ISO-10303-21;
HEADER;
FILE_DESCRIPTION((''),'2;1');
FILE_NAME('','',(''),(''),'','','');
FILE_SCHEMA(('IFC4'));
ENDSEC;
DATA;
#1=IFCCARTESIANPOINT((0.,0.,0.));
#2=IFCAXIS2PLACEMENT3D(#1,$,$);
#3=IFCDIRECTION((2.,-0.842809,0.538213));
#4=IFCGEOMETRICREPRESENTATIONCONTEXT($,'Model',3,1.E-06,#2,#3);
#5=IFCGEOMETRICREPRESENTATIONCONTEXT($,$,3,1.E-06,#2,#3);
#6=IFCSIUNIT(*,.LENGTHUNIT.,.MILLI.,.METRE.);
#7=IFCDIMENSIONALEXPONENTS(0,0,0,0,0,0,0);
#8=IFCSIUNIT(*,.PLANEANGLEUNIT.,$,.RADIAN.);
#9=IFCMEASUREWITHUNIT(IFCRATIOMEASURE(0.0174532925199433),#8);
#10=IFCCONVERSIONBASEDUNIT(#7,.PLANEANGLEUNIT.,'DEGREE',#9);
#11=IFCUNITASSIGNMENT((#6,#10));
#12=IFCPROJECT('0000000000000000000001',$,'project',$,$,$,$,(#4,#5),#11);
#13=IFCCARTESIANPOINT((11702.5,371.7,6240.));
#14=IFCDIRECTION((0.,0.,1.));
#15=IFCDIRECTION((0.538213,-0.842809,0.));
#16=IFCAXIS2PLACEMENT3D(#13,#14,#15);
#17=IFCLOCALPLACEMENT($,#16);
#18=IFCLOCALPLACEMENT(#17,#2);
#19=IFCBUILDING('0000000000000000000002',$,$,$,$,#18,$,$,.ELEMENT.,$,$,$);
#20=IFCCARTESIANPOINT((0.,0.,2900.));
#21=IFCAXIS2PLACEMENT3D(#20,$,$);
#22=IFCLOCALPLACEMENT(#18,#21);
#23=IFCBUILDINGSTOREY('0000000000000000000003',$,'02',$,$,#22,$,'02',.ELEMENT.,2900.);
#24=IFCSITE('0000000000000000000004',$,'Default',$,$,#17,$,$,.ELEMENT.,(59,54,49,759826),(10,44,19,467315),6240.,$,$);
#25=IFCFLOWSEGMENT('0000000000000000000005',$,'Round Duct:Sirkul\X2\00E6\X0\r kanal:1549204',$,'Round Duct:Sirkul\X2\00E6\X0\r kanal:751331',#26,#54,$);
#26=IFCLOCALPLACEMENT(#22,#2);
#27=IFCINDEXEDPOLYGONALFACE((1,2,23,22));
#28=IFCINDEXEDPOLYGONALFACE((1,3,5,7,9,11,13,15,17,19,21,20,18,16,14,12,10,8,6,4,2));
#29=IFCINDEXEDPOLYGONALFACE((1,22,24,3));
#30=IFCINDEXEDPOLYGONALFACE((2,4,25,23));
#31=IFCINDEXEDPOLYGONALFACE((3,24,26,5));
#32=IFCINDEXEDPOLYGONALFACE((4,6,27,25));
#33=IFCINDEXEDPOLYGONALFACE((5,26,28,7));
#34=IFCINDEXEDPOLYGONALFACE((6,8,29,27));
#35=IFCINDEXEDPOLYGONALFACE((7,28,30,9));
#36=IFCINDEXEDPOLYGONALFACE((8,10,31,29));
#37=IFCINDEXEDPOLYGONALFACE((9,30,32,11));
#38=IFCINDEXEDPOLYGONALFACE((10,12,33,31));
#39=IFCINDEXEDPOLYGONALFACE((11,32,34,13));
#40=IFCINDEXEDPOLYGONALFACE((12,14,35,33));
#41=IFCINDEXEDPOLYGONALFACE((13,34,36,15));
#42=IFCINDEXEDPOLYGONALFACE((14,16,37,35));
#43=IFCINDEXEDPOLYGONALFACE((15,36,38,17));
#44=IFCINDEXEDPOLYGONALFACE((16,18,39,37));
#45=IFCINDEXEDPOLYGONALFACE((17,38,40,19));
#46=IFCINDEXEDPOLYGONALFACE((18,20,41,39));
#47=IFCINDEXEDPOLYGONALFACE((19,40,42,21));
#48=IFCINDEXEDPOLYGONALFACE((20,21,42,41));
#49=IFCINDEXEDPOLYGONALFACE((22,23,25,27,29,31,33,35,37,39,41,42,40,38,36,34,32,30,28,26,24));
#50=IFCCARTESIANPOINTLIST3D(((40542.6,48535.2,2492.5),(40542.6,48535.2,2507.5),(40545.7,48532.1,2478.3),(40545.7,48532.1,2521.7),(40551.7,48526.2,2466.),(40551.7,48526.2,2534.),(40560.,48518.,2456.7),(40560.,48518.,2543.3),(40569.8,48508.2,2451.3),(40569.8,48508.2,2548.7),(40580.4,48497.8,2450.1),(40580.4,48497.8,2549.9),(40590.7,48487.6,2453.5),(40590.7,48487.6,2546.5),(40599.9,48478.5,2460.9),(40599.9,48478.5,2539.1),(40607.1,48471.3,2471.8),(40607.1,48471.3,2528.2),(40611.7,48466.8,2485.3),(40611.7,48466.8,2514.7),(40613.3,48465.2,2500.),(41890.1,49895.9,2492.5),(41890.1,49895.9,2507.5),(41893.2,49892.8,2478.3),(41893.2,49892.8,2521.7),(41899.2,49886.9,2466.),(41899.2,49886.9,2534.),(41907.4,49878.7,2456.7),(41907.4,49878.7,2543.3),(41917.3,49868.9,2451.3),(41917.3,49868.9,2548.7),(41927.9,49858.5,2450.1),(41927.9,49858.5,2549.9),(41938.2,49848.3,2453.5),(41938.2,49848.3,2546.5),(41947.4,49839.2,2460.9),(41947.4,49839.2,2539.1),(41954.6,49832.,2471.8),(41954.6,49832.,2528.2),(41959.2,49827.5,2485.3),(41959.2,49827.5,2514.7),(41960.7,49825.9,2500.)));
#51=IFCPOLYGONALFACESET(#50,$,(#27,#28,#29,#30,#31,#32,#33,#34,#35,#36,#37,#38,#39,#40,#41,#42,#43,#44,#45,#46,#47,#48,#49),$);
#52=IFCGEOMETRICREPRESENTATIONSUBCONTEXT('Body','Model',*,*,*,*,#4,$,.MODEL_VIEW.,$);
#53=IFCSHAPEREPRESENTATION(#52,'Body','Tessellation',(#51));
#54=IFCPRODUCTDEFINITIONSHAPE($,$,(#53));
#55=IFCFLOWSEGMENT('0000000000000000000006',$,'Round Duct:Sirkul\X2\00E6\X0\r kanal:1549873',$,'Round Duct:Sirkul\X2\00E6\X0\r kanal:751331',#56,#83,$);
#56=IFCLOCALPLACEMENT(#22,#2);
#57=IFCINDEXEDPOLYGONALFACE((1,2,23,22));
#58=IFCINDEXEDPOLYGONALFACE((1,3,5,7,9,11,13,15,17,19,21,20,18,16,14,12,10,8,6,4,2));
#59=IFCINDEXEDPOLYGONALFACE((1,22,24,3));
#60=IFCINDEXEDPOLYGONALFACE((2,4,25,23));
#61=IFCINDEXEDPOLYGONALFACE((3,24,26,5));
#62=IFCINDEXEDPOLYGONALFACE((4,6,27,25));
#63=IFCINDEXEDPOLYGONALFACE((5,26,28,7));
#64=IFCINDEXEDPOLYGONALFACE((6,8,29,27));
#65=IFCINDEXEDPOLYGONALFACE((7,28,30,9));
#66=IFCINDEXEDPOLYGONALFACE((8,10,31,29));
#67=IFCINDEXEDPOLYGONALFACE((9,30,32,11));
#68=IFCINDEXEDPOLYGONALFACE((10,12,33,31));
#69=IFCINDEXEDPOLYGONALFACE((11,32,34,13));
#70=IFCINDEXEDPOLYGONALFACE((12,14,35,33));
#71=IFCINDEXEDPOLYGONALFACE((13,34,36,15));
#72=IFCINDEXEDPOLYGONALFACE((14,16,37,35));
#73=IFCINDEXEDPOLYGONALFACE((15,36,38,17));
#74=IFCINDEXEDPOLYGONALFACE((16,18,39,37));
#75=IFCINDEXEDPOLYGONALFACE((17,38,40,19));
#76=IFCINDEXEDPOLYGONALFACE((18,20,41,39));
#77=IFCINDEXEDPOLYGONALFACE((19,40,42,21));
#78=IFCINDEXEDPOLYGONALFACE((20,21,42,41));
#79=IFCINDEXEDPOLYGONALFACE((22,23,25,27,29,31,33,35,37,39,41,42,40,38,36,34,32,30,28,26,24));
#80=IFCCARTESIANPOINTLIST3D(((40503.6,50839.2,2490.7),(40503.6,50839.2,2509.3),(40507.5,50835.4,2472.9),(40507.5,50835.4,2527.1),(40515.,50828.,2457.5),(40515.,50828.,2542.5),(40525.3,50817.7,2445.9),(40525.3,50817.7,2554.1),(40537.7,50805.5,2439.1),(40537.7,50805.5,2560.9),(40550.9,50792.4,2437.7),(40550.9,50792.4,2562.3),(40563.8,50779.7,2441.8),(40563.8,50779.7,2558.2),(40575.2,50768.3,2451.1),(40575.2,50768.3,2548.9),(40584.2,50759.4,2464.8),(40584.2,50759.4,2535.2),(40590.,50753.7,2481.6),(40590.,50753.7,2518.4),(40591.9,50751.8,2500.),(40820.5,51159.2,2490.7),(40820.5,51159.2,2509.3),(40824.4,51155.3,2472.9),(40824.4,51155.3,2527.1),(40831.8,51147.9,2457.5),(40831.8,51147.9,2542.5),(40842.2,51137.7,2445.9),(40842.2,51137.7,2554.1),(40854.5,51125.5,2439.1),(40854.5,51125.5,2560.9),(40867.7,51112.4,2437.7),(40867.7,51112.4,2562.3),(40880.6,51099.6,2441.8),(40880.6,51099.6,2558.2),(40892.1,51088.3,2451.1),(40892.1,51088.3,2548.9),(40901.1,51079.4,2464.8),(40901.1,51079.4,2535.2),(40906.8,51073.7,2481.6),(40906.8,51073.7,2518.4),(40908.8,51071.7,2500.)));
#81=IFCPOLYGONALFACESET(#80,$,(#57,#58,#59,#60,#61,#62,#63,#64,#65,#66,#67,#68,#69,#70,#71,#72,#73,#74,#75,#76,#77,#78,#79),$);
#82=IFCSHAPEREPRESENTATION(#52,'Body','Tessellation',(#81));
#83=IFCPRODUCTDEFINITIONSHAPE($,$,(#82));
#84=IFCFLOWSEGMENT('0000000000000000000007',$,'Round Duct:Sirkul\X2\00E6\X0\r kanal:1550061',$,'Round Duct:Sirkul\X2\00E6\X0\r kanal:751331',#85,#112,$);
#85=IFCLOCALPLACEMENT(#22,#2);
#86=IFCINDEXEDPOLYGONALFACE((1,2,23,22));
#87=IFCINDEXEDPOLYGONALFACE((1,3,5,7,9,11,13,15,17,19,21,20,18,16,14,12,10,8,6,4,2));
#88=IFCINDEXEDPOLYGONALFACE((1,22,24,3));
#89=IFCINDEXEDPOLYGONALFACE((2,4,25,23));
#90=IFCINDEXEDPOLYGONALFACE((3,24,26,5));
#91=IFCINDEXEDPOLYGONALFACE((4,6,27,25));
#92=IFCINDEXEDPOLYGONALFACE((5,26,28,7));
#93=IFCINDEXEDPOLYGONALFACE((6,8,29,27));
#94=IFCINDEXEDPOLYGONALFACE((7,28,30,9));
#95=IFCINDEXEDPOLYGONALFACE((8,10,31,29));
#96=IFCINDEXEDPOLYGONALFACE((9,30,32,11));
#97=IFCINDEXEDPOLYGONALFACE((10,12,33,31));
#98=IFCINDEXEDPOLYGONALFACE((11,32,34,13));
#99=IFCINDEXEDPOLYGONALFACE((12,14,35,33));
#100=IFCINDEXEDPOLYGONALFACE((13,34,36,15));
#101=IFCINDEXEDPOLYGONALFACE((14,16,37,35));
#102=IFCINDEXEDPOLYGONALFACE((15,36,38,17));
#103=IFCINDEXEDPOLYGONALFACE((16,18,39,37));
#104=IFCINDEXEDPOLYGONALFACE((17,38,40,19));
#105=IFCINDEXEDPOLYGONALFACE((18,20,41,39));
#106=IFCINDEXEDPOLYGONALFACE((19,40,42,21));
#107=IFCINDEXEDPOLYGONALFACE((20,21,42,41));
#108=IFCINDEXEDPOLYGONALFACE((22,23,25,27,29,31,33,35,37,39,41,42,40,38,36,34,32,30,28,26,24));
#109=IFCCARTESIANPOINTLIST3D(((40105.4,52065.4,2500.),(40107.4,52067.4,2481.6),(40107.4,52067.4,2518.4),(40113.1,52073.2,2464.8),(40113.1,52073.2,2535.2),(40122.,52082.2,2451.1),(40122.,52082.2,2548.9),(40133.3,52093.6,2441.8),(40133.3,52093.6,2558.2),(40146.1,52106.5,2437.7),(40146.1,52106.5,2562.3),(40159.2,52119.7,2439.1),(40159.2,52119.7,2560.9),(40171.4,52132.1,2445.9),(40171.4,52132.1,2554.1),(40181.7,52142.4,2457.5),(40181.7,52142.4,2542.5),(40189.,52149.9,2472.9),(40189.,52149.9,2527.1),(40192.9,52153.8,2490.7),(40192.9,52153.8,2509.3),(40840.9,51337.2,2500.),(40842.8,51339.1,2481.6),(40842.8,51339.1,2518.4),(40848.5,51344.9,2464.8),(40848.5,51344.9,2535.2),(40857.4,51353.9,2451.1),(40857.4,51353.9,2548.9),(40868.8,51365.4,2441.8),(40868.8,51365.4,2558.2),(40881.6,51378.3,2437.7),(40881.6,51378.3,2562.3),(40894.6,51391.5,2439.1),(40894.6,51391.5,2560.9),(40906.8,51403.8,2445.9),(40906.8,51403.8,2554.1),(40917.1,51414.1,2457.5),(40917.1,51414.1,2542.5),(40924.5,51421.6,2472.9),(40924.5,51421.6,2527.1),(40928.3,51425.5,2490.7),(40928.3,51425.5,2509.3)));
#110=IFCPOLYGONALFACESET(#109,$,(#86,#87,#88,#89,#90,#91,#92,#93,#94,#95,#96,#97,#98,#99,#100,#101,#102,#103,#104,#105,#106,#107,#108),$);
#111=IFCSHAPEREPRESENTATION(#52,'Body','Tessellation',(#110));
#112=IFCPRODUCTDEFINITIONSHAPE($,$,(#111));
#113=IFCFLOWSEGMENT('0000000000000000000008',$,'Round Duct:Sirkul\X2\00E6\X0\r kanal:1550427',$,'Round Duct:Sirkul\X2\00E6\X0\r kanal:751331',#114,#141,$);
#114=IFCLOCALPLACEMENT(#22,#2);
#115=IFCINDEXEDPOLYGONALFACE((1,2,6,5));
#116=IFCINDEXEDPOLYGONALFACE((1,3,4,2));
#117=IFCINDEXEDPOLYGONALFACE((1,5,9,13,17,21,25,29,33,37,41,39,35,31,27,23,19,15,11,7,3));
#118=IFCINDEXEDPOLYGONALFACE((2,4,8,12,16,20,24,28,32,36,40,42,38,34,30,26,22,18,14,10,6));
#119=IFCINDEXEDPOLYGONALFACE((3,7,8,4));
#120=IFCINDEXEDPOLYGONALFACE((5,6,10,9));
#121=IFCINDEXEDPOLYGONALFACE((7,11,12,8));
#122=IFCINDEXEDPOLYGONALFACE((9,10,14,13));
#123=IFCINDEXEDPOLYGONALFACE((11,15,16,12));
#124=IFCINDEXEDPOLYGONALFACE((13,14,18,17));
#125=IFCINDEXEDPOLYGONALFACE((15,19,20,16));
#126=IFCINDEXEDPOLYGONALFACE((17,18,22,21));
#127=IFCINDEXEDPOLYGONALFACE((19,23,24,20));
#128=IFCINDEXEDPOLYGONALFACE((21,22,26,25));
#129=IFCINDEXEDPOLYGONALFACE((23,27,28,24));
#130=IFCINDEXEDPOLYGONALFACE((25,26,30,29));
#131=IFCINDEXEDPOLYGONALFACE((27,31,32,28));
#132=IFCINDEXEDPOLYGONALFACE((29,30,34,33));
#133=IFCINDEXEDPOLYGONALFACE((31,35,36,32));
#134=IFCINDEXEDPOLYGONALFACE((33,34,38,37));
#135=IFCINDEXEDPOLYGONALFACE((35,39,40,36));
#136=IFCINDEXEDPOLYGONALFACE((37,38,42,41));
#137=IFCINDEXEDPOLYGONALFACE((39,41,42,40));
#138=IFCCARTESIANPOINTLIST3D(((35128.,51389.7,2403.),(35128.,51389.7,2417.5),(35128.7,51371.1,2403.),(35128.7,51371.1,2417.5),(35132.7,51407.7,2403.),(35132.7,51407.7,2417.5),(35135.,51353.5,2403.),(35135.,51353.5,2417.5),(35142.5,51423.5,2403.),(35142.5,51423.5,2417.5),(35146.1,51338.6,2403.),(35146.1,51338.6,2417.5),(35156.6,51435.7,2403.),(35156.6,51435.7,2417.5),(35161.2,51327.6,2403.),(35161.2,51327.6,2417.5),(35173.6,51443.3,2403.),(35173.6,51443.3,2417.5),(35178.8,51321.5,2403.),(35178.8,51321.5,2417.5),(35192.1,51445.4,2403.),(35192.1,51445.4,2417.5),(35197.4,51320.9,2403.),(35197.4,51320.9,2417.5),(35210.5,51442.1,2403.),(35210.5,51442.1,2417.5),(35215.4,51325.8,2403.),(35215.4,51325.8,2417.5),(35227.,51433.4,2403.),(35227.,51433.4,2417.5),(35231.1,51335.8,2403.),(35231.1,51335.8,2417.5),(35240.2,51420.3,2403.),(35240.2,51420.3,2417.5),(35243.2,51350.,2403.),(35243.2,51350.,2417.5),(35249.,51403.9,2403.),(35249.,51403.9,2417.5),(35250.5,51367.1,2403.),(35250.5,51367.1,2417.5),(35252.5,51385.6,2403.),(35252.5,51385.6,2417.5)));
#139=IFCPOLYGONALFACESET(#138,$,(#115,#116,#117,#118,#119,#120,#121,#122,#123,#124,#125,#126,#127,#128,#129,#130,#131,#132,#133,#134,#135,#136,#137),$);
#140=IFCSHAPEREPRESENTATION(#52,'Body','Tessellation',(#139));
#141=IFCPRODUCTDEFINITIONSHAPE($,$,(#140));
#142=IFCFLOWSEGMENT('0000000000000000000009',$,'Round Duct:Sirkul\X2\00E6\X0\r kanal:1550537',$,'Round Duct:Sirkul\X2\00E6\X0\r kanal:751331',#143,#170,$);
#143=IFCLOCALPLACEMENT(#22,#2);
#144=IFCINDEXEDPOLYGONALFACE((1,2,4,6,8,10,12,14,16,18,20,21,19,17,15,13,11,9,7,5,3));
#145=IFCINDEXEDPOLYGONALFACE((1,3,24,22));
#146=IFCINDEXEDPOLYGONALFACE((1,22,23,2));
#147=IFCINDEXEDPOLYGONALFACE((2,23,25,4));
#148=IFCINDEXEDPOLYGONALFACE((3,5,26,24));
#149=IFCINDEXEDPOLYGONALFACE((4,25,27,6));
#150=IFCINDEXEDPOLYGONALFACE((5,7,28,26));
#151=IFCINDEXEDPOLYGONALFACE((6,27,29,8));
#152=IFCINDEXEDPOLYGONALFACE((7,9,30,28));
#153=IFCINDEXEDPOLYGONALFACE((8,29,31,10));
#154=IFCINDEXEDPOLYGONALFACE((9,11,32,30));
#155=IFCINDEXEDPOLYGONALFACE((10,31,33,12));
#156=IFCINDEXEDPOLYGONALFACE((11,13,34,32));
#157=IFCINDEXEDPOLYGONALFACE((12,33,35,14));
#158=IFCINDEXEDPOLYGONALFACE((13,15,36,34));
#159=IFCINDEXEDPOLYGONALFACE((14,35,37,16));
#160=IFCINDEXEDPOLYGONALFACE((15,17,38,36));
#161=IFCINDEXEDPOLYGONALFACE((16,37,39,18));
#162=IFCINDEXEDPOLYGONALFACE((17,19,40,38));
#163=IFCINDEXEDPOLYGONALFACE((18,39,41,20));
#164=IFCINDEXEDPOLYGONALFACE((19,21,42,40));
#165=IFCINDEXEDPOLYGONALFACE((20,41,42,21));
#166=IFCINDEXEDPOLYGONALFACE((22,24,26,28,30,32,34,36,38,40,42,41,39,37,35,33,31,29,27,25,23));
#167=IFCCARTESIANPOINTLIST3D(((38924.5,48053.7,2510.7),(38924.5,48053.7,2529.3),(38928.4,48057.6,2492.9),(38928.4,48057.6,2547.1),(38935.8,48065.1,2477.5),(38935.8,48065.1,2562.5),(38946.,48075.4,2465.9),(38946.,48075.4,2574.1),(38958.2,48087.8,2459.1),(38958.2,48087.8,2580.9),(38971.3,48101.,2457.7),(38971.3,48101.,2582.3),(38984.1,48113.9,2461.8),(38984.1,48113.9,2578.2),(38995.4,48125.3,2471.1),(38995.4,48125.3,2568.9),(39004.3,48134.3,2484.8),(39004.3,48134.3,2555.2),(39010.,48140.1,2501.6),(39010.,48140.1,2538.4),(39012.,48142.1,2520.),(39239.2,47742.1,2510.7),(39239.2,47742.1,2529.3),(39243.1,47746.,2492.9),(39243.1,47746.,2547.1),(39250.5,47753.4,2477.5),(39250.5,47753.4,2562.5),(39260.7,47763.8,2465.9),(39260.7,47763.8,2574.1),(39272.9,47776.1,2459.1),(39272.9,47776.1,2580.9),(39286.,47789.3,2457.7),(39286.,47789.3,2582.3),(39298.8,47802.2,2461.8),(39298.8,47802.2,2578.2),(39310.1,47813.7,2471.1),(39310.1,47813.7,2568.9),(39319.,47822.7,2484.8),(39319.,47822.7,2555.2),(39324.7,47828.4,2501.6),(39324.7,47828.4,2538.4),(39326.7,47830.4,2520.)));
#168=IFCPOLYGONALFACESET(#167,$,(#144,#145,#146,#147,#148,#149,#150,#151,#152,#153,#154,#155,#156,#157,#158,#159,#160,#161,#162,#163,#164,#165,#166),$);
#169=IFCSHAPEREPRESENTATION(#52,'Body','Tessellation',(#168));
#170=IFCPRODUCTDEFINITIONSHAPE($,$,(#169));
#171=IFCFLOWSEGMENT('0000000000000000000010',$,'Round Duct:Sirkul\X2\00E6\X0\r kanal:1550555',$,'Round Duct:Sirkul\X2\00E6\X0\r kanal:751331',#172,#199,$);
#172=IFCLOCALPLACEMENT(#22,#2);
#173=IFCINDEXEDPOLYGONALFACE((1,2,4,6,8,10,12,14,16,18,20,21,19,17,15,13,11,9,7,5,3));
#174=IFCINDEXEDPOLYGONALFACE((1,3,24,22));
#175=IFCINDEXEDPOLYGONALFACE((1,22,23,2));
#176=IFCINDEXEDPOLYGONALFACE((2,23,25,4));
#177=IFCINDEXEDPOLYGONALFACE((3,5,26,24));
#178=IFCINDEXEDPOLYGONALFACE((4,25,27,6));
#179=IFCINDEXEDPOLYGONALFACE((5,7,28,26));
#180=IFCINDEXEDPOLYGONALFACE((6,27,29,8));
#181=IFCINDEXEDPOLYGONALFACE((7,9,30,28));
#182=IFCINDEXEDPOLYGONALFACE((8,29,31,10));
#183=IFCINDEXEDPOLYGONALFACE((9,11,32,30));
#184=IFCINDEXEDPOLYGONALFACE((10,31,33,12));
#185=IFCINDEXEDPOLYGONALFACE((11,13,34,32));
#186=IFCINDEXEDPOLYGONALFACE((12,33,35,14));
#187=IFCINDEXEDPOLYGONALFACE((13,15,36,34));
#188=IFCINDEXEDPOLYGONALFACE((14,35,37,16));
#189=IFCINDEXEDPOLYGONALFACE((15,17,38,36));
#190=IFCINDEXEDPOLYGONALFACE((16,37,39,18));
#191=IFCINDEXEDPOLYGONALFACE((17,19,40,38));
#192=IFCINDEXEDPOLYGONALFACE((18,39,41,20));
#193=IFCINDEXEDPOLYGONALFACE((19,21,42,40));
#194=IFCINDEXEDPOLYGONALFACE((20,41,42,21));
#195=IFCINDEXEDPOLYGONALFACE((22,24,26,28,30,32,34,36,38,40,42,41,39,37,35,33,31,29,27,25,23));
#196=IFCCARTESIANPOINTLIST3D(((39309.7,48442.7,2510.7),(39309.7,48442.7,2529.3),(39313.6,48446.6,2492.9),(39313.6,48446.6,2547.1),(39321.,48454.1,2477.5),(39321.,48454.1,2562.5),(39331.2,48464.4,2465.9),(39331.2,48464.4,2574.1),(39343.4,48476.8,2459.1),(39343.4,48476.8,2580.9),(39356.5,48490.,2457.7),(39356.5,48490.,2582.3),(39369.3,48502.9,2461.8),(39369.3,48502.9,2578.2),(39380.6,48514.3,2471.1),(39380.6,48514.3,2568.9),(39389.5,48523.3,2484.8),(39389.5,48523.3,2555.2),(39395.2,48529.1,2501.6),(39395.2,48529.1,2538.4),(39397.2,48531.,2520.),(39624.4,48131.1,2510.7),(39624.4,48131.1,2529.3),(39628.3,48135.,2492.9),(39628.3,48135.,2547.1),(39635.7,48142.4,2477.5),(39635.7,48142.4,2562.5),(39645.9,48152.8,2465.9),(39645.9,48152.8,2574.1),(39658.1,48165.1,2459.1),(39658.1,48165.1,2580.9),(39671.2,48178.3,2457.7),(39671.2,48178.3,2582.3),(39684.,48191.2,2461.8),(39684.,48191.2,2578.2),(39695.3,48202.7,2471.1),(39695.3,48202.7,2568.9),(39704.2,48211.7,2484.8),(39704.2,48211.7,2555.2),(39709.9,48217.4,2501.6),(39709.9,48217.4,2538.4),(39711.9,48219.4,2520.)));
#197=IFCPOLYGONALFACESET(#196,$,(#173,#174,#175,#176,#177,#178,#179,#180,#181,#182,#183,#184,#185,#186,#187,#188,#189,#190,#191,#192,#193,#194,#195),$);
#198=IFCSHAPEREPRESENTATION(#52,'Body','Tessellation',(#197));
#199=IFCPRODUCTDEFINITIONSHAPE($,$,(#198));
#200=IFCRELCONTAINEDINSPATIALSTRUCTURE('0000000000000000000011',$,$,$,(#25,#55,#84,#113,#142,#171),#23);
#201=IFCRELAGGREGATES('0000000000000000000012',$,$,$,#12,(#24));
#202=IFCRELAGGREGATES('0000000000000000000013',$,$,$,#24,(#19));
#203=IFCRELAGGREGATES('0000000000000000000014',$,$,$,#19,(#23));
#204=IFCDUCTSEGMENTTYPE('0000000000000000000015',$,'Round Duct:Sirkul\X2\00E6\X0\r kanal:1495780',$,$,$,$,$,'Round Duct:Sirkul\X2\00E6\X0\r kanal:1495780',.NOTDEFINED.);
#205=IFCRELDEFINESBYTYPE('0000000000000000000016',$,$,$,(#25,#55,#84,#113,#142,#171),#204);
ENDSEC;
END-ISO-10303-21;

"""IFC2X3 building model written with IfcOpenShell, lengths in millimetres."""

from ifc_helpers import new_model, entity, si_unit, converted_unit, direction, frame, frame_2d, origin, origin_2d_with_axis, place, context, subcontext, project, spatial, circle, extrude, type_object, element, save


model = new_model("IFC2X3")

# Units and contexts
model_context = context("Model", 3, precision=1e-06, world=origin(), true_north=direction((2.0, -0.842809, 0.538213)))
context_of_model = context(None, 3, precision=1e-06, world=origin(), true_north=direction((2.0, -0.842809, 0.538213)))
body_context = subcontext(model_context, "Body", "Model", "MODEL_VIEW")
ifc_project = project(units=[si_unit("LENGTHUNIT", "METRE", prefix="MILLI"), converted_unit("PLANEANGLEUNIT", "DEGREE", entity("IfcRatioMeasure", 0.0174532925199433), si_unit("PLANEANGLEUNIT", "RADIAN"), dimensions=[0, 0, 0, 0, 0, 0, 0])], contexts=[model_context, context_of_model])

# Site, building, storey
site_placement = place(None, frame((11702.5, 371.7, 6240.0), z_axis=(0.0, 0.0, 1.0), x_axis=(0.538213, -0.842809, 0.0)))
site = spatial("IfcSite", under=ifc_project, at=site_placement, Name="Default", CompositionType="ELEMENT", RefLatitude=(59, 54, 49, 759826), RefLongitude=(10, 44, 19, 467315), RefElevation=6240.0)
building_placement = place(site_placement, origin())
building = spatial("IfcBuilding", under=site, at=building_placement, CompositionType="ELEMENT")
storey_placement = place(building_placement, frame((0.0, 0.0, 2900.0)))
storey = spatial("IfcBuildingStorey", under=building, at=storey_placement, Name="02", LongName="02", CompositionType="ELEMENT", Elevation=2900.0)

# Flow segments
duct_segment_type_1 = type_object("IfcDuctSegmentType", Name="Round Duct:Sirkulær kanal:1495780", ElementType="Round Duct:Sirkulær kanal:1495780", PredefinedType="NOTDEFINED")
flow_segment_1_placement = place(storey_placement, origin())
element("IfcFlowSegment", 1, at=flow_segment_1_placement, inside=storey, type_object=duct_segment_type_1, Name="Round Duct:Sirkulær kanal:1549204", ObjectType="Round Duct:Sirkulær kanal:751331", context=body_context, shape_type="SweptSolid", body=[
    extrude(circle(Radius=50.0, at=origin_2d_with_axis()), frame((40577.7, 48500.4, 2500.0), z_axis=(0.703643, 0.710554, 0.0), x_axis=(0.710554, -0.703643, 0.0)), (0.0, 0.0, 1.0), 1915.0),
])
flow_segment_2_placement = place(storey_placement, origin())
element("IfcFlowSegment", 2, at=flow_segment_2_placement, inside=storey, type_object=duct_segment_type_1, Name="Round Duct:Sirkulær kanal:1549873", ObjectType="Round Duct:Sirkulær kanal:751331", context=body_context, shape_type="SweptSolid", body=[
    extrude(circle(Radius=62.5, at=frame_2d((0.0, 0.0), x_axis=(1.0, 0.0))), frame((40547.5, 50795.7, 2500.0), z_axis=(0.703643, 0.710554, 0.0), x_axis=(0.710554, -0.703643, 0.0)), (0.0, 0.0, 1.0), 450.3),
])
flow_segment_3_placement = place(storey_placement, origin())
element("IfcFlowSegment", 3, at=flow_segment_3_placement, inside=storey, type_object=duct_segment_type_1, Name="Round Duct:Sirkulær kanal:1550061", ObjectType="Round Duct:Sirkulær kanal:751331", context=body_context, shape_type="SweptSolid", body=[
    extrude(circle(Radius=62.5, at=origin_2d_with_axis()), frame((40884.8, 51381.6, 2500.0), z_axis=(-0.710554, 0.703643, 0.0), x_axis=(-0.703643, -0.710554, 0.0)), (0.0, 0.0, 1.0), 1035.0),
])
flow_segment_4_placement = place(storey_placement, origin())
element("IfcFlowSegment", 4, at=flow_segment_4_placement, inside=storey, type_object=duct_segment_type_1, Name="Round Duct:Sirkulær kanal:1550427", ObjectType="Round Duct:Sirkulær kanal:751331", context=body_context, shape_type="SweptSolid", body=[
    extrude(circle(Radius=62.5, at=frame_2d((0.0, 0.0), x_axis=(1.0, 0.0))), frame((35190.1, 51383.0, 2403.0), z_axis=(0.0, 0.0, 1.0), x_axis=(-0.703643, -0.710554, 0.0)), (0.0, 0.0, 1.0), 14.5),
])
flow_segment_5_placement = place(storey_placement, origin())
element("IfcFlowSegment", 5, at=flow_segment_5_placement, inside=storey, type_object=duct_segment_type_1, Name="Round Duct:Sirkulær kanal:1550537", ObjectType="Round Duct:Sirkulær kanal:751331", context=body_context, shape_type="SweptSolid", body=[
    extrude(circle(Radius=62.5, at=origin_2d_with_axis()), frame((39282.7, 47786.0, 2520.0), z_axis=(-0.710554, 0.703643, 0.0), x_axis=(0.703643, 0.710554, 0.0)), (0.0, 0.0, 1.0), 442.9),
])
flow_segment_6_placement = place(storey_placement, origin())
element("IfcFlowSegment", 6, at=flow_segment_6_placement, inside=storey, type_object=duct_segment_type_1, Name="Round Duct:Sirkulær kanal:1550555", ObjectType="Round Duct:Sirkulær kanal:751331", context=body_context, shape_type="SweptSolid", body=[
    extrude(circle(Radius=62.5, at=origin_2d_with_axis()), frame((39353.2, 48486.6, 2520.0), z_axis=(0.710554, -0.703643, 0.0), x_axis=(0.703643, 0.710554, 0.0)), (0.0, 0.0, 1.0), 442.9),
])

save(model, "model.ifc")
